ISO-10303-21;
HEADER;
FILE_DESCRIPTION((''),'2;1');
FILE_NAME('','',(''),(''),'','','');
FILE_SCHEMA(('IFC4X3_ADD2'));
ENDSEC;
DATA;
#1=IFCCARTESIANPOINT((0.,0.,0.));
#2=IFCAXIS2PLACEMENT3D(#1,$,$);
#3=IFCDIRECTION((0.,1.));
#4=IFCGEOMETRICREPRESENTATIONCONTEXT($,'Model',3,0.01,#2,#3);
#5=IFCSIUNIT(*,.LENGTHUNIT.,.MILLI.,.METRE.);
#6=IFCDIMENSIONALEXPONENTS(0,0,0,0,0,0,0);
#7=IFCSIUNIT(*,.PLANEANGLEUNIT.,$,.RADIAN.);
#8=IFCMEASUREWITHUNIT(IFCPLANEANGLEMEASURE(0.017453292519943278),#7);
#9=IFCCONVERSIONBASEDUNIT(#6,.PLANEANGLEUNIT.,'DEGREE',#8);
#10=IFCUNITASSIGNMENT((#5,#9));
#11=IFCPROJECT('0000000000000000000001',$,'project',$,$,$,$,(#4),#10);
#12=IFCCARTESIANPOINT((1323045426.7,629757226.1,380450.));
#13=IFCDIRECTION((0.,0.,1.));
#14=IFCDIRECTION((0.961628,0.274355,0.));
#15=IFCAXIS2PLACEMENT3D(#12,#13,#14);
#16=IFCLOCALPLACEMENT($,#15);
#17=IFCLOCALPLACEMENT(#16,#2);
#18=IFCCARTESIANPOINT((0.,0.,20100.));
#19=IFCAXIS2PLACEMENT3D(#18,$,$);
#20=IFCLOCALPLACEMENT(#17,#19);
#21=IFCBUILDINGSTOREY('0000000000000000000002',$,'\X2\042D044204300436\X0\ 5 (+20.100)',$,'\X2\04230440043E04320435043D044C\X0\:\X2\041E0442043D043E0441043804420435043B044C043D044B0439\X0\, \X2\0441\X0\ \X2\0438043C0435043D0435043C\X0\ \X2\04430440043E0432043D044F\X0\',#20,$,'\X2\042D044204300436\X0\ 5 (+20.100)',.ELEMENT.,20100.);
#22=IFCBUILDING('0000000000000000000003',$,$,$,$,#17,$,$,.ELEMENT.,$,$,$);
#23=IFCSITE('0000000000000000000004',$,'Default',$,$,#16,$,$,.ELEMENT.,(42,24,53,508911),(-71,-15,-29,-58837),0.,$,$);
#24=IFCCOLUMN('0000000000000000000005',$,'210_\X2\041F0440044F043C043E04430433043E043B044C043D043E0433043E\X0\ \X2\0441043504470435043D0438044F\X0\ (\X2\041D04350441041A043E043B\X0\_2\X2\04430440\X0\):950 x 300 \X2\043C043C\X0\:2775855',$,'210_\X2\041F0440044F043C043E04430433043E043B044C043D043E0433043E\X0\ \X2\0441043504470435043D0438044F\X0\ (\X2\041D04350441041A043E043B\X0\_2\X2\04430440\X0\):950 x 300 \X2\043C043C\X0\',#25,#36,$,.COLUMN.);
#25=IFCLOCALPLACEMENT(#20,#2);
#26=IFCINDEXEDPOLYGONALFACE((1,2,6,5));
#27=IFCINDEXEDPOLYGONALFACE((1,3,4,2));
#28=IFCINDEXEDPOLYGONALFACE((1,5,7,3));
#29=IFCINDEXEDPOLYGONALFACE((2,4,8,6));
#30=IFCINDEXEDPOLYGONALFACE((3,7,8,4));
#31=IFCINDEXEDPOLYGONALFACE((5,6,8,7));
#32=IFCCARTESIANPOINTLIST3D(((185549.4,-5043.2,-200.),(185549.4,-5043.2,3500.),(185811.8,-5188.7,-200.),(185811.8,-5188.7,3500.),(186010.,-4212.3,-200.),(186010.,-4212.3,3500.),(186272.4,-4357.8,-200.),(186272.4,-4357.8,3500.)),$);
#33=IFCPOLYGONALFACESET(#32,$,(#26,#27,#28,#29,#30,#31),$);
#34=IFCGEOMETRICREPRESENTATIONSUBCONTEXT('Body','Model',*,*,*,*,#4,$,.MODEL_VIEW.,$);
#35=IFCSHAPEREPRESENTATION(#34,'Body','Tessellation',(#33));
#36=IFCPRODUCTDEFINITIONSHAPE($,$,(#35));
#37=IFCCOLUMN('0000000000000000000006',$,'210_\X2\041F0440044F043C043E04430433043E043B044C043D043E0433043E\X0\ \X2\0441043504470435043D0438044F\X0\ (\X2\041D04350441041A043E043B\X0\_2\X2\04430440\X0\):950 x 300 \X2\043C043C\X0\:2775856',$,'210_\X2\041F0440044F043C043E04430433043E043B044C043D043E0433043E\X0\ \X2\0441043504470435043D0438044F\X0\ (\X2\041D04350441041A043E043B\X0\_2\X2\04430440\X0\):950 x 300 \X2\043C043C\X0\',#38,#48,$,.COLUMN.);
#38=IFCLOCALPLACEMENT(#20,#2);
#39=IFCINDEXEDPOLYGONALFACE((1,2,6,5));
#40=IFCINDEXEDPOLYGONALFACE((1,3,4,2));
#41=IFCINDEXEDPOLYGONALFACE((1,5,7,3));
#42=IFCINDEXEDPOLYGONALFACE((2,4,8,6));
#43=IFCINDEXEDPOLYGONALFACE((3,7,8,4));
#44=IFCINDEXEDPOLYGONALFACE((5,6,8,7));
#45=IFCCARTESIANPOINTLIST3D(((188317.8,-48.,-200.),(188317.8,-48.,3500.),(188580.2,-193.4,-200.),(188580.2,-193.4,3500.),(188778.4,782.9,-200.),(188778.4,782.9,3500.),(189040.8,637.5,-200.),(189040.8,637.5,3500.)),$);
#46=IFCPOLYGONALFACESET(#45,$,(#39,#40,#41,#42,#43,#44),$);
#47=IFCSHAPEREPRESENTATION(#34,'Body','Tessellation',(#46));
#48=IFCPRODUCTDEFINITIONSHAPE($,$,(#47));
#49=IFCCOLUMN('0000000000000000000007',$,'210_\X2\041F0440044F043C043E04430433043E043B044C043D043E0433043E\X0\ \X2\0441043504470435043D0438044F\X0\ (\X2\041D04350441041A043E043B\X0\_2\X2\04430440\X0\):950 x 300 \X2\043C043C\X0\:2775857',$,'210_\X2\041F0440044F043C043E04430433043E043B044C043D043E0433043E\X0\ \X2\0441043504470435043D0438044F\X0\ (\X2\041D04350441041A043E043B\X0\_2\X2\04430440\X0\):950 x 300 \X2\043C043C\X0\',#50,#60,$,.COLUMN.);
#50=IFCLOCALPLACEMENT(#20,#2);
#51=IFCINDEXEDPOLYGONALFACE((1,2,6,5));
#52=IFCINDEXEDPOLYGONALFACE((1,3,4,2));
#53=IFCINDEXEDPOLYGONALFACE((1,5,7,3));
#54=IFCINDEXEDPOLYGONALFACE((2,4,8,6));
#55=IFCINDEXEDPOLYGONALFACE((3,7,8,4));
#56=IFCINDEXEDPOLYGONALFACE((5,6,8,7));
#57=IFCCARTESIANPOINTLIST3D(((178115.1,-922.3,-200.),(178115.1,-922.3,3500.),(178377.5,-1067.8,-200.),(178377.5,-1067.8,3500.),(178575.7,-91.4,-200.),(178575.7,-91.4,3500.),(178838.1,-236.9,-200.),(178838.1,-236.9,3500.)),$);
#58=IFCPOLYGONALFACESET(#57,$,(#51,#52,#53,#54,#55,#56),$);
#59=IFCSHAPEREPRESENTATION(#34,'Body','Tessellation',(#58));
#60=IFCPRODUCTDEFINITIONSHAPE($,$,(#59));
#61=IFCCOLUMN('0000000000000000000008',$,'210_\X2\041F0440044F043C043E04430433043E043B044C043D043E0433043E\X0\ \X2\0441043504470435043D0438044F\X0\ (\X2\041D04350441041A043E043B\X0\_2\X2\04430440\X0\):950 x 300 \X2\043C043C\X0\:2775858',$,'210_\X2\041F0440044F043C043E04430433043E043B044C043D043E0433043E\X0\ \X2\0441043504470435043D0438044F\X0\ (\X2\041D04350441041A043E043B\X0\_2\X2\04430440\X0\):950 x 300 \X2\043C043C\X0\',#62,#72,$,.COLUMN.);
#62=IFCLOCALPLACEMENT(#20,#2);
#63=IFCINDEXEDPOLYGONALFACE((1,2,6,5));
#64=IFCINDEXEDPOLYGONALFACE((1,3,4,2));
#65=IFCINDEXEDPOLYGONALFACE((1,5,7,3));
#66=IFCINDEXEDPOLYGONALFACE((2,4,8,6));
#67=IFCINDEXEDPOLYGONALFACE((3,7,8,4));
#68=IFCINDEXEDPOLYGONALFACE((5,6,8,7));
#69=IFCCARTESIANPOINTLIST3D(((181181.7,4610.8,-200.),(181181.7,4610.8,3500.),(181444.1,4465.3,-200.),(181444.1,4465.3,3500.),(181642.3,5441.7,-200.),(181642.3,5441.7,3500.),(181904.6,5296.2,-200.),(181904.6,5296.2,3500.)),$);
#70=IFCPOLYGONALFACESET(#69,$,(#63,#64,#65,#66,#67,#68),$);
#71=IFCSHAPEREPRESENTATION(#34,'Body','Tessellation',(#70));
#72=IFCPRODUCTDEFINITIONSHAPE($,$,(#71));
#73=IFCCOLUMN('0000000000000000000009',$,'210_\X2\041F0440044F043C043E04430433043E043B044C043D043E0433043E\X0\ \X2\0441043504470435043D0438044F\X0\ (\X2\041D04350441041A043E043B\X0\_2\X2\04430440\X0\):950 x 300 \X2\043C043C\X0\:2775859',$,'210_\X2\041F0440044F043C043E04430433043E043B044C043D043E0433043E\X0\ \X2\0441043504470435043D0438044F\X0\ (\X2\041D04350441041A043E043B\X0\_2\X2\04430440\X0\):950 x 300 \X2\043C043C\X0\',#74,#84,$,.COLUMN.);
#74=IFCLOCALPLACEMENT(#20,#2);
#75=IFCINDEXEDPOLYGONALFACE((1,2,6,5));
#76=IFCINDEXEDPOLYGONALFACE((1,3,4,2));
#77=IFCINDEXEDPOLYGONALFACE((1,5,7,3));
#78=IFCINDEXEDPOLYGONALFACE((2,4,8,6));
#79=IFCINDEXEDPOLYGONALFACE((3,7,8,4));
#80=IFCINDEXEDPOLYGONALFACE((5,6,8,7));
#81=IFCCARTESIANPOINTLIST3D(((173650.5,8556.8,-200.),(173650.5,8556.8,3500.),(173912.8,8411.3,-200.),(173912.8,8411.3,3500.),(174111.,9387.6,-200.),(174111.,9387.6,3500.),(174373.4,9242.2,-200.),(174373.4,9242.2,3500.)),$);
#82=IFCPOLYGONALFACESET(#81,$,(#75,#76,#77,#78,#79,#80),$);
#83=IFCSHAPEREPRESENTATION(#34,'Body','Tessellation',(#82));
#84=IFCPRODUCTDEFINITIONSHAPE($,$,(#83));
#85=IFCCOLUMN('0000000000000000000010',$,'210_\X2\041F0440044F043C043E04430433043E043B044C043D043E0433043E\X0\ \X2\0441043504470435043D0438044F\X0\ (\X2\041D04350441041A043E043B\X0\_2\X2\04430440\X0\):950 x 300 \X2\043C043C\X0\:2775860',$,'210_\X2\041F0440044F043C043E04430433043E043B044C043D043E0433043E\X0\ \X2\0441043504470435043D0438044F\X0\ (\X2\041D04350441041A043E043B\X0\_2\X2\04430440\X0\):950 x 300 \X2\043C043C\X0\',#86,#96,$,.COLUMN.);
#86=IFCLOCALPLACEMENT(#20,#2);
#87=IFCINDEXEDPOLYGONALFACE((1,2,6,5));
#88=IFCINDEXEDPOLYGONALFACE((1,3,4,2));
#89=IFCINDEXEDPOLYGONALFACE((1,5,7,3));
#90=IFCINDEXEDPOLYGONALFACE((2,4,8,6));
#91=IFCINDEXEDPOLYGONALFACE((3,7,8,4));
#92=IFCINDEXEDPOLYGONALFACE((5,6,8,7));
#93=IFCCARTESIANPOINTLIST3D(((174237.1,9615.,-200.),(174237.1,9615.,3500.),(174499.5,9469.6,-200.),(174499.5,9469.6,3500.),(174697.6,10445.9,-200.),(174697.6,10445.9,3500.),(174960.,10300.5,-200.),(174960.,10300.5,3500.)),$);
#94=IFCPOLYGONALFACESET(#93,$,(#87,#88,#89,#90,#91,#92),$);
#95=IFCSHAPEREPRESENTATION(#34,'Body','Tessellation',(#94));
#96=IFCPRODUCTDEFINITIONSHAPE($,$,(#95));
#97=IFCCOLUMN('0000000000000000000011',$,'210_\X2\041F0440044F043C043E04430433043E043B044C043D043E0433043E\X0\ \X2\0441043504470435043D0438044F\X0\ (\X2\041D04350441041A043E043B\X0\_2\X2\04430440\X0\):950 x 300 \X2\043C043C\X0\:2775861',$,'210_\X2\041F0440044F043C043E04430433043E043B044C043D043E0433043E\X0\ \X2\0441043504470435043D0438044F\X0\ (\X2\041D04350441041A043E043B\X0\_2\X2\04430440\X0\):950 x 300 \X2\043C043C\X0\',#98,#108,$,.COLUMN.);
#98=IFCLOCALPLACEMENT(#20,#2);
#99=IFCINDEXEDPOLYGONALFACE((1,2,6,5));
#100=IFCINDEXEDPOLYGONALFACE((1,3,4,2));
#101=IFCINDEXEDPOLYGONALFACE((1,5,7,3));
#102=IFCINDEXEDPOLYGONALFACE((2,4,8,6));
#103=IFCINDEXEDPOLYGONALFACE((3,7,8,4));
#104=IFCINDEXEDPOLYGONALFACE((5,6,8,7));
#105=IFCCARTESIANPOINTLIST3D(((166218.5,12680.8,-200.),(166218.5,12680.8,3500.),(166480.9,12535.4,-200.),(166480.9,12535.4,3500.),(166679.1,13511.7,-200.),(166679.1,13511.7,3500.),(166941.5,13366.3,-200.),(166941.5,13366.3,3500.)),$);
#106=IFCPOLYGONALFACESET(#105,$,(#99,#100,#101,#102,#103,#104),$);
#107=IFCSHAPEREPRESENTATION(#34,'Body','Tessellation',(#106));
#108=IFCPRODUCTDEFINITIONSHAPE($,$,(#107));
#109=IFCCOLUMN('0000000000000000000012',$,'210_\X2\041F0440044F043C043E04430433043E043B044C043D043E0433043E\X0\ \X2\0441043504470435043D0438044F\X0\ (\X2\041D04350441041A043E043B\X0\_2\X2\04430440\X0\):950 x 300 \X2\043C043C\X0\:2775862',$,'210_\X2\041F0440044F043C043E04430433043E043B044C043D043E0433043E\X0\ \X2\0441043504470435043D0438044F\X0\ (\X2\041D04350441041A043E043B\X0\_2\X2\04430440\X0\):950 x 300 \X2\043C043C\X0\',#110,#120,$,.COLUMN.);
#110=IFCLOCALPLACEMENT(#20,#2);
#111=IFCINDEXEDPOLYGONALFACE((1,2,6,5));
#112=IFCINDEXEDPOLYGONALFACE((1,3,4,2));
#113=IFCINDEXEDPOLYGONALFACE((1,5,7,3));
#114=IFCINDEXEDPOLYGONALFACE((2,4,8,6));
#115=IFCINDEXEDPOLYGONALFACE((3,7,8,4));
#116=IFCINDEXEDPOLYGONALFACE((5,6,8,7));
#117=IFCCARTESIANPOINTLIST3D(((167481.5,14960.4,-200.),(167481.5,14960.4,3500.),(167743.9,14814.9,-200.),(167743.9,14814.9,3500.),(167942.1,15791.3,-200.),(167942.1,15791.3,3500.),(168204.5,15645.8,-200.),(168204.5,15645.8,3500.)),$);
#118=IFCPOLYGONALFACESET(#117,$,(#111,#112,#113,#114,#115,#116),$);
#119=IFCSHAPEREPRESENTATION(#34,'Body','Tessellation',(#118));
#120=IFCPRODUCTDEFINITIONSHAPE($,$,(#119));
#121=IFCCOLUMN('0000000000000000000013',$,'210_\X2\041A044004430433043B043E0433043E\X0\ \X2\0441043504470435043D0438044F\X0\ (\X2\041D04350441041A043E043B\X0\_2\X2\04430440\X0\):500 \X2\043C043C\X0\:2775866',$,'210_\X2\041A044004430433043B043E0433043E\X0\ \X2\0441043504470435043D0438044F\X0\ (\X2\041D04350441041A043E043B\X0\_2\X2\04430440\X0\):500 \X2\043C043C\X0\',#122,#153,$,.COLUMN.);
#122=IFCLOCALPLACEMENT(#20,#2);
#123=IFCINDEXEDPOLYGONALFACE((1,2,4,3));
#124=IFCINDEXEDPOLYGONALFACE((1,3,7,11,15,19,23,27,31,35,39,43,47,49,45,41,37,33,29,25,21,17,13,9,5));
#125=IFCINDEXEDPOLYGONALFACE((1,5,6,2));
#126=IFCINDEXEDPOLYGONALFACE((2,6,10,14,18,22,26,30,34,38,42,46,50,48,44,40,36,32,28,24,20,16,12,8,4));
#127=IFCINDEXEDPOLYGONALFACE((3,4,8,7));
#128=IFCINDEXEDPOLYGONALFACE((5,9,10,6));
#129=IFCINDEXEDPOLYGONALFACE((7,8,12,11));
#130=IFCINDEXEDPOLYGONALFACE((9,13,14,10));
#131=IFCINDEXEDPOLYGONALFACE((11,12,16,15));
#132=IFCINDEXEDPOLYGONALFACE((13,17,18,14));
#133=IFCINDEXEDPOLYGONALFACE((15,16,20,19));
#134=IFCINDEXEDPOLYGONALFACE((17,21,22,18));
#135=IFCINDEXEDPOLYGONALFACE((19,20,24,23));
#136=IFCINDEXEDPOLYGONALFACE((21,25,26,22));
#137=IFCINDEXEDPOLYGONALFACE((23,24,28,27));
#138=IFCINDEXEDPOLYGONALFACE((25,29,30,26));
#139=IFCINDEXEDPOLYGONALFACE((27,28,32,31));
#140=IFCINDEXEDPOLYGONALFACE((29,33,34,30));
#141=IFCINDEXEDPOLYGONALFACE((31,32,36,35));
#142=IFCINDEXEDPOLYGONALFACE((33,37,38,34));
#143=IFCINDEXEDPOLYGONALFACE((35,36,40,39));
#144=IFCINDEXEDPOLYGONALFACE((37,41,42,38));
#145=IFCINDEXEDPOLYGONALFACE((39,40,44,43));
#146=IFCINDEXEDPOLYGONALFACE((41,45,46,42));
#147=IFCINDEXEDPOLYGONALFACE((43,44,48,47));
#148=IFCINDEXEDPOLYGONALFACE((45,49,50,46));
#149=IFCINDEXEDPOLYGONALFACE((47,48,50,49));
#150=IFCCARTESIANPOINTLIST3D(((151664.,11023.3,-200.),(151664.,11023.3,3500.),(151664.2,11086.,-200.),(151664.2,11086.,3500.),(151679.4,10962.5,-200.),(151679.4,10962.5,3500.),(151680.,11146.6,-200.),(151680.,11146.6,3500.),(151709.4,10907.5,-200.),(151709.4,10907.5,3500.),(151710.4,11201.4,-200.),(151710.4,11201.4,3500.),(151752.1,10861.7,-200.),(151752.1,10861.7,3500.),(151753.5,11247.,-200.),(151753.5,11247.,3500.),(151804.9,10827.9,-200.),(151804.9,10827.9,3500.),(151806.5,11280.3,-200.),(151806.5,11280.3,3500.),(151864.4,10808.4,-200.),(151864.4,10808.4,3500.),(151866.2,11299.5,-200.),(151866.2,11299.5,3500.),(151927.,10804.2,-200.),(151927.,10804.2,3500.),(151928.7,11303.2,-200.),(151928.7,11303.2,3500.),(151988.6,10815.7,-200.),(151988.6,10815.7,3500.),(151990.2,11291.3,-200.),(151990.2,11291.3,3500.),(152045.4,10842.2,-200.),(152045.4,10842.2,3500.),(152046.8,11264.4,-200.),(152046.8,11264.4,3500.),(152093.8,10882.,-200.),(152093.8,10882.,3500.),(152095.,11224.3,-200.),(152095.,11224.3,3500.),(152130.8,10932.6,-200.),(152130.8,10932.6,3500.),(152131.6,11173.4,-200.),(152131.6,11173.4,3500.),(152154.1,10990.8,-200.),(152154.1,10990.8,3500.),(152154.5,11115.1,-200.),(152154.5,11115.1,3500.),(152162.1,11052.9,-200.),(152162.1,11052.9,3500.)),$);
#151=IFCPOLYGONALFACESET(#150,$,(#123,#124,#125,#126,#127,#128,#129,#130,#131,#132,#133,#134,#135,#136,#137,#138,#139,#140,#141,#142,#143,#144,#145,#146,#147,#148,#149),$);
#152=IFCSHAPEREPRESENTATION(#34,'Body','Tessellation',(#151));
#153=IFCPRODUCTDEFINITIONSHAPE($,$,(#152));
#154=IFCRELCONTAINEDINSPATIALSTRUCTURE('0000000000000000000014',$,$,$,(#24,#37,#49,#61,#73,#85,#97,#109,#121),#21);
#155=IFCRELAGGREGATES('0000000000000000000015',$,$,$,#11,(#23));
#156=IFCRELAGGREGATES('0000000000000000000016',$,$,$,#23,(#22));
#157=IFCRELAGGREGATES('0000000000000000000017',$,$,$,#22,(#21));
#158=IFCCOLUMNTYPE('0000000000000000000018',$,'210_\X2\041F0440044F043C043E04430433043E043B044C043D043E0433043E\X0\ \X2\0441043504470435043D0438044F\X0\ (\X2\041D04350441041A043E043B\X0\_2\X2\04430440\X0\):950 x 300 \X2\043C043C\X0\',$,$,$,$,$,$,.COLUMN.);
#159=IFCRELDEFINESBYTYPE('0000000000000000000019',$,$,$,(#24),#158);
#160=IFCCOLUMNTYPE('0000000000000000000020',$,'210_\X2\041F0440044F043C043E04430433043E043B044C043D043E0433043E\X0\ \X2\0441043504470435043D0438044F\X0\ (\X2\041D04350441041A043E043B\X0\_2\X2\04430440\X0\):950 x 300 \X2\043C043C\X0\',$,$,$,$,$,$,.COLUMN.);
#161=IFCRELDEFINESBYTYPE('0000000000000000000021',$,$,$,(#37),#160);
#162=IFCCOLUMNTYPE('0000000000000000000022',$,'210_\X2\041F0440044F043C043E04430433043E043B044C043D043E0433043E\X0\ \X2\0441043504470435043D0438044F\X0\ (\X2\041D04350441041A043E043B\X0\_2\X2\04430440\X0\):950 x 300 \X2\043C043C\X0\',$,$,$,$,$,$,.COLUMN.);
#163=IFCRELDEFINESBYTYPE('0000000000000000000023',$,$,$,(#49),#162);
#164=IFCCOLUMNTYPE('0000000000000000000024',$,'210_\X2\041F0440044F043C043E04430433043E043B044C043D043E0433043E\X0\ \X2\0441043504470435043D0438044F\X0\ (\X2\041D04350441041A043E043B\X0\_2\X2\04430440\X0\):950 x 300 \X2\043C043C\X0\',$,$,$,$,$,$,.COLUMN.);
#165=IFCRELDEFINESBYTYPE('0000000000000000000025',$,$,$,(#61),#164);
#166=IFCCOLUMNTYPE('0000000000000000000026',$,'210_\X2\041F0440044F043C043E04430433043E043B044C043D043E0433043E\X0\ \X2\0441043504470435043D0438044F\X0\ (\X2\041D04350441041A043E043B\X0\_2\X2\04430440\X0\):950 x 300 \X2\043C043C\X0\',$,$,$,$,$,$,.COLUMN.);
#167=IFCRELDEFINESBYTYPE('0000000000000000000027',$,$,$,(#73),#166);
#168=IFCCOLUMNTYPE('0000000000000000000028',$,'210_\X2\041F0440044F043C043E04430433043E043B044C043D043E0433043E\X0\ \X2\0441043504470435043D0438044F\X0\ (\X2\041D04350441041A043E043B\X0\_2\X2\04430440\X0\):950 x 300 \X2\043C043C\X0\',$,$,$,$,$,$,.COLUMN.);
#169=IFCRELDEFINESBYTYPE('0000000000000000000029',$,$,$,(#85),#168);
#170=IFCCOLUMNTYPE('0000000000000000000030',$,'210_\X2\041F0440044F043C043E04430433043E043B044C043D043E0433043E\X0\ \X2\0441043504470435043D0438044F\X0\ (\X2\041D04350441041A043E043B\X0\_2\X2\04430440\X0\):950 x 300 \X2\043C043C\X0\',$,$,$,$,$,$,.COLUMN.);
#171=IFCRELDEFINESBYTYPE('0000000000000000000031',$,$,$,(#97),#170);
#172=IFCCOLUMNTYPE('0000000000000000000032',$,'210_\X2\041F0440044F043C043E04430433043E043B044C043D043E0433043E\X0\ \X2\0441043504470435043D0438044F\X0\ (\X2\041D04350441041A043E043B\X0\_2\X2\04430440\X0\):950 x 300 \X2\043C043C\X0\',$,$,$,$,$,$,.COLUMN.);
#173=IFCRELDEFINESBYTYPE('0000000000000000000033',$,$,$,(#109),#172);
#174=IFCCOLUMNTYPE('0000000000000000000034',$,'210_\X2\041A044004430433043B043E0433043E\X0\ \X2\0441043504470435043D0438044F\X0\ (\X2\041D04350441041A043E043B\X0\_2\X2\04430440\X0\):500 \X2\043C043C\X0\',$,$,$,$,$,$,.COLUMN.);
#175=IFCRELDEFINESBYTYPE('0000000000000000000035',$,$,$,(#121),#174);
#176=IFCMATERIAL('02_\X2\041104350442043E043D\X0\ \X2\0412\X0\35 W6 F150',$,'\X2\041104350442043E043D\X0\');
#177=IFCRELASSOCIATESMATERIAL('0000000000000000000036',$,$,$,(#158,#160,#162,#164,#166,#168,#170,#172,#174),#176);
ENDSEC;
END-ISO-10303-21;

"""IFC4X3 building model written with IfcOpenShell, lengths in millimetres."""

from ifc_helpers import new_model, entity, si_unit, converted_unit, direction, frame, frame_2d, origin, origin_2d_with_axis, place, context, subcontext, project, spatial, rectangle, circle, extrude, source, transform, mapped, material, material_profile, profile_set, type_object, type_shapes, element, save


model = new_model("IFC4X3")

# Units and contexts
model_context = context("Model", 3, precision=0.01, world=origin(), true_north=direction((0.0, 1.0)))
body_context = subcontext(model_context, "Body", "Model", "MODEL_VIEW")
ifc_project = project(units=[si_unit("LENGTHUNIT", "METRE", prefix="MILLI"), converted_unit("PLANEANGLEUNIT", "DEGREE", entity("IfcPlaneAngleMeasure", 0.017453292519943278), si_unit("PLANEANGLEUNIT", "RADIAN"), dimensions=[0, 0, 0, 0, 0, 0, 0])], contexts=[model_context])

# Site, building, storey
site_placement = place(None, frame((1323045426.7, 629757226.1, 380450.0), z_axis=(0.0, 0.0, 1.0), x_axis=(0.961628, 0.274355, 0.0)))
site = spatial("IfcSite", under=ifc_project, at=site_placement, Name="Default", CompositionType="ELEMENT", RefLatitude=(42, 24, 53, 508911), RefLongitude=(-71, -15, -29, -58837), RefElevation=0.0)
building_placement = place(site_placement, origin())
building = spatial("IfcBuilding", under=site, at=building_placement, CompositionType="ELEMENT")
storey_placement = place(building_placement, frame((0.0, 0.0, 20100.0)))
storey = spatial("IfcBuildingStorey", under=building, at=storey_placement, Name="Этаж 5 (+20.100)", ObjectType="Уровень:Относительный, с именем уровня", LongName="Этаж 5 (+20.100)", CompositionType="ELEMENT", Elevation=20100.0)

# Columns
ifc_material_1 = material(Name="02_Бетон В35 W6 F150", Category="Бетон")
ifc_material_profile_1 = material_profile(ifc_material_1, rectangle(XDim=300.0, YDim=950.0, at=frame_2d((0.0, 0.0), x_axis=(1.0, 0.0))), Name="950 x 300 мм")
ifc_profile_set_1 = profile_set([ifc_material_profile_1], Name="950 x 300 мм")
column_type_1 = type_object("IfcColumnType", Name="210_Прямоугольного сечения (НесКол_2ур):950 x 300 мм", PredefinedType="COLUMN", material=ifc_profile_set_1)
shared_shape_1 = source(origin(), body_context, "Body", "SweptSolid", [
    extrude(rectangle(XDim=300.0, YDim=950.0, at=frame_2d((0.0, 0.0), x_axis=(1.0, 0.0))), frame((185910.9, -4700.5, 19900.0), z_axis=(0.0, 0.0, 1.0), x_axis=(-0.87462, 0.48481, 0.0)), (0.0, 0.0, 1.0), 3700.0),
])
type_shapes(column_type_1, [shared_shape_1])
column_1_placement = place(storey_placement, frame((0.0, 0.0, -20100.0)))
element("IfcColumn", 1, at=column_1_placement, inside=storey, type_object=column_type_1, Name="210_Прямоугольного сечения (НесКол_2ур):950 x 300 мм:2775855", ObjectType="210_Прямоугольного сечения (НесКол_2ур):950 x 300 мм", PredefinedType="COLUMN", context=body_context, shape_type="MappedRepresentation", body=[
    mapped(shared_shape_1, transform((0.0, 0.0, 0.0), scale=1.0)),
])
column_type_2 = type_object("IfcColumnType", Name="210_Прямоугольного сечения (НесКол_2ур):950 x 300 мм", PredefinedType="COLUMN", material=ifc_profile_set_1)
shared_shape_2 = source(origin(), body_context, "Body", "SweptSolid", [
    extrude(rectangle(XDim=300.0, YDim=950.0, at=frame_2d((0.0, 0.0), x_axis=(1.0, 0.0))), frame((188679.3, 294.7, 19900.0), z_axis=(0.0, 0.0, 1.0), x_axis=(-0.87462, 0.48481, 0.0)), (0.0, 0.0, 1.0), 3700.0),
])
type_shapes(column_type_2, [shared_shape_2])
column_2_placement = place(storey_placement, frame((0.0, 0.0, -20100.0)))
element("IfcColumn", 2, at=column_2_placement, inside=storey, type_object=column_type_2, Name="210_Прямоугольного сечения (НесКол_2ур):950 x 300 мм:2775856", ObjectType="210_Прямоугольного сечения (НесКол_2ур):950 x 300 мм", PredefinedType="COLUMN", context=body_context, shape_type="MappedRepresentation", body=[
    mapped(shared_shape_2, transform((0.0, 0.0, 0.0), scale=1.0)),
])
column_type_3 = type_object("IfcColumnType", Name="210_Прямоугольного сечения (НесКол_2ур):950 x 300 мм", PredefinedType="COLUMN", material=ifc_profile_set_1)
shared_shape_3 = source(origin(), body_context, "Body", "SweptSolid", [
    extrude(rectangle(XDim=300.0, YDim=950.0, at=frame_2d((0.0, 0.0), x_axis=(1.0, 0.0))), frame((178476.6, -579.6, 19900.0), z_axis=(0.0, 0.0, 1.0), x_axis=(-0.87462, 0.48481, 0.0)), (0.0, 0.0, 1.0), 3700.0),
])
type_shapes(column_type_3, [shared_shape_3])
column_3_placement = place(storey_placement, frame((0.0, 0.0, -20100.0)))
element("IfcColumn", 3, at=column_3_placement, inside=storey, type_object=column_type_3, Name="210_Прямоугольного сечения (НесКол_2ур):950 x 300 мм:2775857", ObjectType="210_Прямоугольного сечения (НесКол_2ур):950 x 300 мм", PredefinedType="COLUMN", context=body_context, shape_type="MappedRepresentation", body=[
    mapped(shared_shape_3, transform((0.0, 0.0, 0.0), scale=1.0)),
])
column_type_4 = type_object("IfcColumnType", Name="210_Прямоугольного сечения (НесКол_2ур):950 x 300 мм", PredefinedType="COLUMN", material=ifc_profile_set_1)
shared_shape_4 = source(origin(), body_context, "Body", "SweptSolid", [
    extrude(rectangle(XDim=300.0, YDim=950.0, at=frame_2d((0.0, 0.0), x_axis=(1.0, 0.0))), frame((181543.2, 4953.5, 19900.0), z_axis=(0.0, 0.0, 1.0), x_axis=(-0.87462, 0.48481, 0.0)), (0.0, 0.0, 1.0), 3700.0),
])
type_shapes(column_type_4, [shared_shape_4])
column_4_placement = place(storey_placement, frame((0.0, 0.0, -20100.0)))
element("IfcColumn", 4, at=column_4_placement, inside=storey, type_object=column_type_4, Name="210_Прямоугольного сечения (НесКол_2ур):950 x 300 мм:2775858", ObjectType="210_Прямоугольного сечения (НесКол_2ур):950 x 300 мм", PredefinedType="COLUMN", context=body_context, shape_type="MappedRepresentation", body=[
    mapped(shared_shape_4, transform((0.0, 0.0, 0.0), scale=1.0)),
])
column_type_5 = type_object("IfcColumnType", Name="210_Прямоугольного сечения (НесКол_2ур):950 x 300 мм", PredefinedType="COLUMN", material=ifc_profile_set_1)
shared_shape_5 = source(origin(), body_context, "Body", "SweptSolid", [
    extrude(rectangle(XDim=300.0, YDim=950.0, at=frame_2d((0.0, 0.0), x_axis=(1.0, 0.0))), frame((174011.9, 8899.5, 19900.0), z_axis=(0.0, 0.0, 1.0), x_axis=(-0.87462, 0.48481, 0.0)), (0.0, 0.0, 1.0), 3700.0),
])
type_shapes(column_type_5, [shared_shape_5])
column_5_placement = place(storey_placement, frame((0.0, 0.0, -20100.0)))
element("IfcColumn", 5, at=column_5_placement, inside=storey, type_object=column_type_5, Name="210_Прямоугольного сечения (НесКол_2ур):950 x 300 мм:2775859", ObjectType="210_Прямоугольного сечения (НесКол_2ур):950 x 300 мм", PredefinedType="COLUMN", context=body_context, shape_type="MappedRepresentation", body=[
    mapped(shared_shape_5, transform((0.0, 0.0, 0.0), scale=1.0)),
])
column_type_6 = type_object("IfcColumnType", Name="210_Прямоугольного сечения (НесКол_2ур):950 x 300 мм", PredefinedType="COLUMN", material=ifc_profile_set_1)
shared_shape_6 = source(origin(), body_context, "Body", "SweptSolid", [
    extrude(rectangle(XDim=300.0, YDim=950.0, at=frame_2d((0.0, 0.0), x_axis=(1.0, 0.0))), frame((174598.6, 9957.8, 19900.0), z_axis=(0.0, 0.0, 1.0), x_axis=(-0.87462, 0.48481, 0.0)), (0.0, 0.0, 1.0), 3700.0),
])
type_shapes(column_type_6, [shared_shape_6])
column_6_placement = place(storey_placement, frame((0.0, 0.0, -20100.0)))
element("IfcColumn", 6, at=column_6_placement, inside=storey, type_object=column_type_6, Name="210_Прямоугольного сечения (НесКол_2ур):950 x 300 мм:2775860", ObjectType="210_Прямоугольного сечения (НесКол_2ур):950 x 300 мм", PredefinedType="COLUMN", context=body_context, shape_type="MappedRepresentation", body=[
    mapped(shared_shape_6, transform((0.0, 0.0, 0.0), scale=1.0)),
])
column_type_7 = type_object("IfcColumnType", Name="210_Прямоугольного сечения (НесКол_2ур):950 x 300 мм", PredefinedType="COLUMN", material=ifc_profile_set_1)
shared_shape_7 = source(origin(), body_context, "Body", "SweptSolid", [
    extrude(rectangle(XDim=300.0, YDim=950.0, at=frame_2d((0.0, 0.0), x_axis=(1.0, 0.0))), frame((166580.0, 13023.6, 19900.0), z_axis=(0.0, 0.0, 1.0), x_axis=(-0.87462, 0.48481, 0.0)), (0.0, 0.0, 1.0), 3700.0),
])
type_shapes(column_type_7, [shared_shape_7])
column_7_placement = place(storey_placement, frame((0.0, 0.0, -20100.0)))
element("IfcColumn", 7, at=column_7_placement, inside=storey, type_object=column_type_7, Name="210_Прямоугольного сечения (НесКол_2ур):950 x 300 мм:2775861", ObjectType="210_Прямоугольного сечения (НесКол_2ур):950 x 300 мм", PredefinedType="COLUMN", context=body_context, shape_type="MappedRepresentation", body=[
    mapped(shared_shape_7, transform((0.0, 0.0, 0.0), scale=1.0)),
])
column_type_8 = type_object("IfcColumnType", Name="210_Прямоугольного сечения (НесКол_2ур):950 x 300 мм", PredefinedType="COLUMN", material=ifc_profile_set_1)
shared_shape_8 = source(origin(), body_context, "Body", "SweptSolid", [
    extrude(rectangle(XDim=300.0, YDim=950.0, at=frame_2d((0.0, 0.0), x_axis=(1.0, 0.0))), frame((167843.0, 15303.1, 19900.0), z_axis=(0.0, 0.0, 1.0), x_axis=(-0.87462, 0.48481, 0.0)), (0.0, 0.0, 1.0), 3700.0),
])
type_shapes(column_type_8, [shared_shape_8])
column_8_placement = place(storey_placement, frame((0.0, 0.0, -20100.0)))
element("IfcColumn", 8, at=column_8_placement, inside=storey, type_object=column_type_8, Name="210_Прямоугольного сечения (НесКол_2ур):950 x 300 мм:2775862", ObjectType="210_Прямоугольного сечения (НесКол_2ур):950 x 300 мм", PredefinedType="COLUMN", context=body_context, shape_type="MappedRepresentation", body=[
    mapped(shared_shape_8, transform((0.0, 0.0, 0.0), scale=1.0)),
])
ifc_material_profile_2 = material_profile(ifc_material_1, circle(Radius=250.0, at=frame_2d((0.0, 0.0), x_axis=(1.0, 0.0))), Name="500 мм")
ifc_profile_set_2 = profile_set([ifc_material_profile_2], Name="500 мм")
column_type_9 = type_object("IfcColumnType", Name="210_Круглого сечения (НесКол_2ур):500 мм", PredefinedType="COLUMN", material=ifc_profile_set_2)
shared_shape_9 = source(origin(), body_context, "Body", "SweptSolid", [
    extrude(circle(Radius=250.0, at=origin_2d_with_axis()), frame((151912.1, 11053.8, 19900.0), z_axis=(0.0, 0.0, 1.0), x_axis=(0.87462, -0.48481, 0.0)), (0.0, 0.0, 1.0), 3700.0),
])
type_shapes(column_type_9, [shared_shape_9])
column_9_placement = place(storey_placement, frame((0.0, 0.0, -20100.0)))
element("IfcColumn", 9, at=column_9_placement, inside=storey, type_object=column_type_9, Name="210_Круглого сечения (НесКол_2ур):500 мм:2775866", ObjectType="210_Круглого сечения (НесКол_2ур):500 мм", PredefinedType="COLUMN", context=body_context, shape_type="MappedRepresentation", body=[
    mapped(shared_shape_9, transform((0.0, 0.0, 0.0), scale=1.0)),
])

save(model, "model.ifc")
